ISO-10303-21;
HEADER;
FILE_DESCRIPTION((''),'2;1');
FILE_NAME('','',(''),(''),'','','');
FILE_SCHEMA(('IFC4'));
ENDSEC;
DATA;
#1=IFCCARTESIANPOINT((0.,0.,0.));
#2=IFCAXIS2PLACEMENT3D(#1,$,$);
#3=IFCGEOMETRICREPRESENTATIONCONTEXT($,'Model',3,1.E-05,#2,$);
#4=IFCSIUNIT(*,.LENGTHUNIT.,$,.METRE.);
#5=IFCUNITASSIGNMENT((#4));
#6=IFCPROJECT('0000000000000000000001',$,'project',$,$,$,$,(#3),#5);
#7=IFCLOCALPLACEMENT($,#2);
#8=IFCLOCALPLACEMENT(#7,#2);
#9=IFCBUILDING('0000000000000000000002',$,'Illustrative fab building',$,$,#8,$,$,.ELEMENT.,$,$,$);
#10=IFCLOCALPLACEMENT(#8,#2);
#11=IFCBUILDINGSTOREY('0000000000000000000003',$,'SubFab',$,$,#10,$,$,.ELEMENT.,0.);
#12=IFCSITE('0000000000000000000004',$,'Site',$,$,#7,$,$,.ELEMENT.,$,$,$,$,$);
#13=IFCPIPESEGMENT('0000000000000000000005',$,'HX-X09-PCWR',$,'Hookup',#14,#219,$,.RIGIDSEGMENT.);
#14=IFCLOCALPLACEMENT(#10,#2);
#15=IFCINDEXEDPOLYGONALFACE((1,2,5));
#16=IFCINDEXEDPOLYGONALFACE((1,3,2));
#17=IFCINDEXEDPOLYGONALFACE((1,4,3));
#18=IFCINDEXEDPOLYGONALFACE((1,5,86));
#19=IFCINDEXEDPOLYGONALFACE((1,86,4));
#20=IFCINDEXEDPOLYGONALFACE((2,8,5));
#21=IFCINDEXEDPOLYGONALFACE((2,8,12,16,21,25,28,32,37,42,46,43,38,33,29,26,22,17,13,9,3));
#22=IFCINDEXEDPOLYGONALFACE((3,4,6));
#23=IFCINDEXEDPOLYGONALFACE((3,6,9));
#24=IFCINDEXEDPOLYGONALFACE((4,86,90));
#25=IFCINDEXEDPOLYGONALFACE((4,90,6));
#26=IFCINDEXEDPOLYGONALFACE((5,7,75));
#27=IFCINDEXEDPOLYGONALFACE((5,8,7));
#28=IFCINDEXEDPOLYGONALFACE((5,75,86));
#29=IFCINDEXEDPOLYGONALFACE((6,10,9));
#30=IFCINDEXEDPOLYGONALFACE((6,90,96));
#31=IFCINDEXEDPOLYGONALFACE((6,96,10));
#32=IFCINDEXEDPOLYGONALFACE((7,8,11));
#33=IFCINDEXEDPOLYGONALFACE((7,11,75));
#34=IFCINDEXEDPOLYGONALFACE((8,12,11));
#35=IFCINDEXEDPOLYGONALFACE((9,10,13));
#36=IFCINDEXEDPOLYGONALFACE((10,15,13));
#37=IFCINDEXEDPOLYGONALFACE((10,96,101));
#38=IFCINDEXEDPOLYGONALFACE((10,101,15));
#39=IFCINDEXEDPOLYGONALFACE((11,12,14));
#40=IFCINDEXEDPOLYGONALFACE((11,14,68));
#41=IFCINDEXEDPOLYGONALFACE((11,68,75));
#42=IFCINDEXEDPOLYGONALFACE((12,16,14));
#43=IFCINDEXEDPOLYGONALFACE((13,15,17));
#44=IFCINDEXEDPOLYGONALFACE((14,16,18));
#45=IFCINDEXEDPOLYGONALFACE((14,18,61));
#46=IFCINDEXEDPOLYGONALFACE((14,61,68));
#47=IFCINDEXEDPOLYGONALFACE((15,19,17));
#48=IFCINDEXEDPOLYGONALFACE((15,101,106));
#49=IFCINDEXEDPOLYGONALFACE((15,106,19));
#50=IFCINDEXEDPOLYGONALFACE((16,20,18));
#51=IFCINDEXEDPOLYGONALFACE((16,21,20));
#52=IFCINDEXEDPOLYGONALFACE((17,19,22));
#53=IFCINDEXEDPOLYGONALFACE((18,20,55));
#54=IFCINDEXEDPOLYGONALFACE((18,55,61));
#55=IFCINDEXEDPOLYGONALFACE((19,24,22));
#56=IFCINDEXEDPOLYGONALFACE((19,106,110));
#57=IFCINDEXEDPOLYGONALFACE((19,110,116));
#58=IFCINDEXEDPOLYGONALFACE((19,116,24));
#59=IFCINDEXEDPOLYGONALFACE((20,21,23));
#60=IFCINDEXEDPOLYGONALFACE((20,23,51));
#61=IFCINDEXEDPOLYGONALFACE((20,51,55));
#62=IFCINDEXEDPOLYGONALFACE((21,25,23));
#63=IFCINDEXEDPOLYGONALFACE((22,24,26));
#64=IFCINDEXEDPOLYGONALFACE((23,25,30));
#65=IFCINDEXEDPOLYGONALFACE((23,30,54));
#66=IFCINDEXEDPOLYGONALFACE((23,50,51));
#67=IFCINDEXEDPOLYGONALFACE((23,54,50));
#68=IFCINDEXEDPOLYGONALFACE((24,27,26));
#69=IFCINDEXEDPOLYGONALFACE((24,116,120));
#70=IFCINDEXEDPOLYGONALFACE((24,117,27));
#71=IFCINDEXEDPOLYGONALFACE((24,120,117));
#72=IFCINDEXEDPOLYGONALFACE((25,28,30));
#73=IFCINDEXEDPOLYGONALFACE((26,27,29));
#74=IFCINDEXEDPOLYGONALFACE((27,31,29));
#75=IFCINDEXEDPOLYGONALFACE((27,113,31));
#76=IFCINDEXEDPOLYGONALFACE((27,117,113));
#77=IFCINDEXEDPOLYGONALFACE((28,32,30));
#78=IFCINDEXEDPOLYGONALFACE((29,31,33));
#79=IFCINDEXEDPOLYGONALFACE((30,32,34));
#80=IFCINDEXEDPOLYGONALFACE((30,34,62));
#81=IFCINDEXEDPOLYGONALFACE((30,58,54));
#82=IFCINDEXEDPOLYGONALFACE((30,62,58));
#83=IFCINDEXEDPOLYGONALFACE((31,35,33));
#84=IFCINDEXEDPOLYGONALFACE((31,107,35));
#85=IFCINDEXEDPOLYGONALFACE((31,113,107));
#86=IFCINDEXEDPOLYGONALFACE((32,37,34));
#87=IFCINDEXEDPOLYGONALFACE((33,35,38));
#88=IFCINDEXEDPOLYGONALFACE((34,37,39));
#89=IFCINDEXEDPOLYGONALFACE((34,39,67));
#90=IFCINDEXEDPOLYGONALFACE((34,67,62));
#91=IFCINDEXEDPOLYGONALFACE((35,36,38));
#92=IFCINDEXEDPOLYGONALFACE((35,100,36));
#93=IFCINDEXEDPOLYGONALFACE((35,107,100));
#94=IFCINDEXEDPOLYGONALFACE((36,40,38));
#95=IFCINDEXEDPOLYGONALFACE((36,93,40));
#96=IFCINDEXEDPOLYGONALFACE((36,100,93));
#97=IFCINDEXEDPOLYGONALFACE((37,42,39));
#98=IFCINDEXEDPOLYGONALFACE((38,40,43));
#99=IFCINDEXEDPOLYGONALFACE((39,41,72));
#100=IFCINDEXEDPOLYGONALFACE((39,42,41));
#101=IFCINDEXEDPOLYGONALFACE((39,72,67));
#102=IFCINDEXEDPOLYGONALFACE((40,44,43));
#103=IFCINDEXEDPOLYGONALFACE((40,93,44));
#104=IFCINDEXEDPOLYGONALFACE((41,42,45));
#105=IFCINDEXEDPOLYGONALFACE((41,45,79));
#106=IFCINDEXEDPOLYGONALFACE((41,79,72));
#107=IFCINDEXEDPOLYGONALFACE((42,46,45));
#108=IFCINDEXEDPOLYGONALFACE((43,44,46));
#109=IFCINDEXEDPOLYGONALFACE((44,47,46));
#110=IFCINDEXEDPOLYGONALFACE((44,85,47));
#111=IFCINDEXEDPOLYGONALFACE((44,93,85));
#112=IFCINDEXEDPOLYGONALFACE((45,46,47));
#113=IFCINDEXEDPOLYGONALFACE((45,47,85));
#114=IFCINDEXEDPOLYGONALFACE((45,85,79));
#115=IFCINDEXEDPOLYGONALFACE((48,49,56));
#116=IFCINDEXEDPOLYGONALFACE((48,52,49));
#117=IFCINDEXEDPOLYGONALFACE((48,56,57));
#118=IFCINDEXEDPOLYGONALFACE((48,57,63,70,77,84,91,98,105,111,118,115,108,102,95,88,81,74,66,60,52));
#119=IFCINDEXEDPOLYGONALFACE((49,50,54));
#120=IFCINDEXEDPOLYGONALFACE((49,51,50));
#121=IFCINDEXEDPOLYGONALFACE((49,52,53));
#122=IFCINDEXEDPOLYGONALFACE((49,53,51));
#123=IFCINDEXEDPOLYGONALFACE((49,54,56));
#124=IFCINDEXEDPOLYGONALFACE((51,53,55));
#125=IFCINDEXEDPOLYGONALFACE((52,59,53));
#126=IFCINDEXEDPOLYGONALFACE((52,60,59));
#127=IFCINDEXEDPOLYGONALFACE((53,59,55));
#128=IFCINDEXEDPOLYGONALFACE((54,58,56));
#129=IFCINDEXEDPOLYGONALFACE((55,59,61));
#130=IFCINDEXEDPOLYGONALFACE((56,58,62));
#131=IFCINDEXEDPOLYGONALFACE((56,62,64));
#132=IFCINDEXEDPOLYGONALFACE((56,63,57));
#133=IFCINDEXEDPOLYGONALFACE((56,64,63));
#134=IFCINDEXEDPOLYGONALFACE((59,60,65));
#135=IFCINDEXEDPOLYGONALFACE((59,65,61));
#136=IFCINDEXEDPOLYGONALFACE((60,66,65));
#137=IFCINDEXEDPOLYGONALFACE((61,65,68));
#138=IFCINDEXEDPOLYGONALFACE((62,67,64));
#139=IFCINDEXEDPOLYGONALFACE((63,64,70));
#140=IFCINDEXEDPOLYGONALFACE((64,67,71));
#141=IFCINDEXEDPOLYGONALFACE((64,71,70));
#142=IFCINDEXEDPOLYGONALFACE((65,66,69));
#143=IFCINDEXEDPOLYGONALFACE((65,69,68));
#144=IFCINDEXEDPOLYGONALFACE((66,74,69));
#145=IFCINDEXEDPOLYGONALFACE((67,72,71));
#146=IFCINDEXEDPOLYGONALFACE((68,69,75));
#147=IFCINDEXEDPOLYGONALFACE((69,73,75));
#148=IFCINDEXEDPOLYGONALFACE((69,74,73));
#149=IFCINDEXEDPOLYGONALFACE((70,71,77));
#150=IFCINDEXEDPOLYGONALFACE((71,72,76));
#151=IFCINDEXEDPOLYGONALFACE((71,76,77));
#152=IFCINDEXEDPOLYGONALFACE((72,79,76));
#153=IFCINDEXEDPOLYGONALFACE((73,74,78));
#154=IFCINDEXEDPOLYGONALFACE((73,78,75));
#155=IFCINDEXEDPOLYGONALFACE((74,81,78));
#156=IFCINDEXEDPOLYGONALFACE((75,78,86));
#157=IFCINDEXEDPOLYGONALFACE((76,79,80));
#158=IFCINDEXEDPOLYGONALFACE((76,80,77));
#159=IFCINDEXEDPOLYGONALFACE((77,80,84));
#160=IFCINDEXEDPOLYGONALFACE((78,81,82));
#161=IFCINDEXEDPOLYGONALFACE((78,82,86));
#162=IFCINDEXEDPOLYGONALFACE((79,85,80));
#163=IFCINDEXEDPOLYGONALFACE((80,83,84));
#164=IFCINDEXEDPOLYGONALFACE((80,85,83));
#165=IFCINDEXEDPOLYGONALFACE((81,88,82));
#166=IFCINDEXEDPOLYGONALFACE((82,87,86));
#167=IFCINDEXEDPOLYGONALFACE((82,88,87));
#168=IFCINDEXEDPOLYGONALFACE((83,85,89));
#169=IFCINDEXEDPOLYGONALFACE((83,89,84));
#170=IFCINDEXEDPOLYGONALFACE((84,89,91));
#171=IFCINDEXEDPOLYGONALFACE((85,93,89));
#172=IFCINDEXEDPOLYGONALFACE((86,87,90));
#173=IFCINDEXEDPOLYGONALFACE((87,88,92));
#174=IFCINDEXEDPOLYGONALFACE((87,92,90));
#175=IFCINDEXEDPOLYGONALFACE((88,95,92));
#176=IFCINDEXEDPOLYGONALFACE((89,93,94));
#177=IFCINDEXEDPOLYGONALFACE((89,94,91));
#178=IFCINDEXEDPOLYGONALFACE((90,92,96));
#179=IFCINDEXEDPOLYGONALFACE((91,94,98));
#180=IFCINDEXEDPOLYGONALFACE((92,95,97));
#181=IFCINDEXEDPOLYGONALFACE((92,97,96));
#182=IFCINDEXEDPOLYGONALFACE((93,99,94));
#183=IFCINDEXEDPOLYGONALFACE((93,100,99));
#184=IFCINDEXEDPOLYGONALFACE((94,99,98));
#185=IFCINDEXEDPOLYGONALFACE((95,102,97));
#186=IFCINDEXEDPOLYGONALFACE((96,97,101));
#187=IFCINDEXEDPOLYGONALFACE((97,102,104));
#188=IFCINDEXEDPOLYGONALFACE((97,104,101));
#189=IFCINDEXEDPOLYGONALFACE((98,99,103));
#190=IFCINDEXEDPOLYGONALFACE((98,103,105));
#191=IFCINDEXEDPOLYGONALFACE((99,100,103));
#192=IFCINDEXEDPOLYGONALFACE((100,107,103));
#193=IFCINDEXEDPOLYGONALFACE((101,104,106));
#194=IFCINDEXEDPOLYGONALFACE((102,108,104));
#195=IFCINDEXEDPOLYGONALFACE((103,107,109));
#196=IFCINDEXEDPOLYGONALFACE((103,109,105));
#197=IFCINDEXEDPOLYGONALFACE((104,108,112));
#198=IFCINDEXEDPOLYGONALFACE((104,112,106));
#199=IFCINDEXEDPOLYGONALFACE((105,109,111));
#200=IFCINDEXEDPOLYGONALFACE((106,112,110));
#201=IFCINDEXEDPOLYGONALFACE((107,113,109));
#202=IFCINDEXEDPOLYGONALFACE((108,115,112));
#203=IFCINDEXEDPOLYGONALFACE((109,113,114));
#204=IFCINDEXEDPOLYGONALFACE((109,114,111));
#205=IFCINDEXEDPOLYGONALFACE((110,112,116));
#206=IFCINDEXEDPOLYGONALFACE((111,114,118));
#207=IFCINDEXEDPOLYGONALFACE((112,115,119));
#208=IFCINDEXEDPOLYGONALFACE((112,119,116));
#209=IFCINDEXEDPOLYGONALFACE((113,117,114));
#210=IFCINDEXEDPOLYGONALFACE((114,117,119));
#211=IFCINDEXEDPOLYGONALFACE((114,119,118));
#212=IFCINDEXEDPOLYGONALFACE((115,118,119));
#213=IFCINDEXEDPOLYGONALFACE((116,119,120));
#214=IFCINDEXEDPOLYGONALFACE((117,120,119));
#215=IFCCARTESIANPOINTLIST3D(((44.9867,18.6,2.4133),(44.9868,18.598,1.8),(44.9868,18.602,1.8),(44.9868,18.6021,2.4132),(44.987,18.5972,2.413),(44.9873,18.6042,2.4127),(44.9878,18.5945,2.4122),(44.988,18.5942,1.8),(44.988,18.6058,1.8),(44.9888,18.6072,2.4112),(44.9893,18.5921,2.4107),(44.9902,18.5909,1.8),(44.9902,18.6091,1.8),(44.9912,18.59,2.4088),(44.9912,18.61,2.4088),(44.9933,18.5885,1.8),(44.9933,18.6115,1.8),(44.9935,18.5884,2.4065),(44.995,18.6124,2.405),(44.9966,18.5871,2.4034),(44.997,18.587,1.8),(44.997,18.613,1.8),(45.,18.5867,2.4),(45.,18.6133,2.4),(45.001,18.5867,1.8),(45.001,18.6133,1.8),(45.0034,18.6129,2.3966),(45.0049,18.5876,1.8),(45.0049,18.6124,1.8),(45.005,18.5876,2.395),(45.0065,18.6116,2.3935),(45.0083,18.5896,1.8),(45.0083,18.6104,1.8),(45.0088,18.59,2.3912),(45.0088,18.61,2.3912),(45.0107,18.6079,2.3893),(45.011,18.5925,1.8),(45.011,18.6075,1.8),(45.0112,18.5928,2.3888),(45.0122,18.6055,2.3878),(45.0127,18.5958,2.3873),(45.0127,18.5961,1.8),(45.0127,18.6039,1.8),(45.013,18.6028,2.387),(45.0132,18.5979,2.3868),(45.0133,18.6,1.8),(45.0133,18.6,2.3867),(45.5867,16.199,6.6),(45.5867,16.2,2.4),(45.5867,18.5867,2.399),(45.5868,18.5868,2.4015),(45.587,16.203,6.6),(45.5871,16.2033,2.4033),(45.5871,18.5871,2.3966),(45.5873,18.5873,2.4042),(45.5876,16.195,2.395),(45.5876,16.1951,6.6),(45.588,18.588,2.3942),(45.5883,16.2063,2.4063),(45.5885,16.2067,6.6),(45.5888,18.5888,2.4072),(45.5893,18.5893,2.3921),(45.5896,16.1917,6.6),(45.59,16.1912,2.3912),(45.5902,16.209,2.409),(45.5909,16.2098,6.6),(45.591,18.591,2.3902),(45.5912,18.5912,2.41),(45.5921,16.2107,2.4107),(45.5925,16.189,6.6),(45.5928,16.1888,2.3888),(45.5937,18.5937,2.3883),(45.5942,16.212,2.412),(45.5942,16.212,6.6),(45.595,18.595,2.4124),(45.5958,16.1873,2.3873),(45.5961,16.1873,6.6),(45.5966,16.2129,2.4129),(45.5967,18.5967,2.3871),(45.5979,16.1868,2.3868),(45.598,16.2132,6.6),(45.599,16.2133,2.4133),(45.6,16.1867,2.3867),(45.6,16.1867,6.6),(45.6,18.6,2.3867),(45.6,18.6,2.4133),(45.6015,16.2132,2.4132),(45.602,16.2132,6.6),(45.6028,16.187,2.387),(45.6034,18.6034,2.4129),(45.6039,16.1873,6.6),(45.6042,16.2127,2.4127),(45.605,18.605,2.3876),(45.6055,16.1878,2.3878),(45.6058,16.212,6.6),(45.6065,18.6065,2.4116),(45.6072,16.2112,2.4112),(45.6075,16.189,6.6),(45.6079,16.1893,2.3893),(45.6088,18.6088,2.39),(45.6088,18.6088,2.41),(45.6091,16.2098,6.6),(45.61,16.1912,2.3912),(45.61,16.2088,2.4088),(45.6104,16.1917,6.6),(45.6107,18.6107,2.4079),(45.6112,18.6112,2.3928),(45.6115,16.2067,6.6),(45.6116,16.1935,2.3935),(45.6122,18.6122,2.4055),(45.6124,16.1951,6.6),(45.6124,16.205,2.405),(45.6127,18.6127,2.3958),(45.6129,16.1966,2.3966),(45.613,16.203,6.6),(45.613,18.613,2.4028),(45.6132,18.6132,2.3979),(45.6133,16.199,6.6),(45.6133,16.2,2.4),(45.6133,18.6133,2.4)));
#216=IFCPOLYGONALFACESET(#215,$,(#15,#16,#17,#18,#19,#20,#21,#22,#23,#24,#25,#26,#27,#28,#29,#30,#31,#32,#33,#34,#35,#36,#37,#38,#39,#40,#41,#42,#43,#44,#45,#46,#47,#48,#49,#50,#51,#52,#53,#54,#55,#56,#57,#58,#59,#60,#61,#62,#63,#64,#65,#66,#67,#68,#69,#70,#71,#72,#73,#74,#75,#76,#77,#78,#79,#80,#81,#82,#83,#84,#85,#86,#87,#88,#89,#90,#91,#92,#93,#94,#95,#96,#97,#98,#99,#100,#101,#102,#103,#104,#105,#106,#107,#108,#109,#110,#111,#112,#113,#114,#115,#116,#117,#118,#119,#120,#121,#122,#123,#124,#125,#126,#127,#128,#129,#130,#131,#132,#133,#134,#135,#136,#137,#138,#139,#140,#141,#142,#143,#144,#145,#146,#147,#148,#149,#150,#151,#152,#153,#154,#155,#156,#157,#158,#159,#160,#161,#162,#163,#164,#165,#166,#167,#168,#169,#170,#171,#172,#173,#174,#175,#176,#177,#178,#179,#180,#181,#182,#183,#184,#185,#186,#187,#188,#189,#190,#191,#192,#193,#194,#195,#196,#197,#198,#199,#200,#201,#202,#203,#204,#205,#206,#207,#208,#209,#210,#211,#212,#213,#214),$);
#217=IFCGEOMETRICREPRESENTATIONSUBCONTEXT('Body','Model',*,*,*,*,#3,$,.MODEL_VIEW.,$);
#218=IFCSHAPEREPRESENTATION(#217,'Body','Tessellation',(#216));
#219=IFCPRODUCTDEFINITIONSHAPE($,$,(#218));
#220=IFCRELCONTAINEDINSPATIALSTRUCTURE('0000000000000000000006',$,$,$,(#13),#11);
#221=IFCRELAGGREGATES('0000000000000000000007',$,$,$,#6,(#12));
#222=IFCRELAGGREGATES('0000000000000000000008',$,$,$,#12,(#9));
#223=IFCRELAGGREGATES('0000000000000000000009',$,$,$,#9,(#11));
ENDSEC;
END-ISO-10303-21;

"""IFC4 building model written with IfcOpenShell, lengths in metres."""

from ifc_helpers import new_model, entity, si_unit, origin, place, context, subcontext, project, spatial, element, save


model = new_model("IFC4")

# Units and contexts
model_context = context("Model", 3, precision=1e-05, world=origin())
body_context = subcontext(model_context, "Body", "Model", "MODEL_VIEW")
ifc_project = project(units=[si_unit("LENGTHUNIT", "METRE")], contexts=[model_context])

# Site, building, storey
site_placement = place(None, origin())
site = spatial("IfcSite", under=ifc_project, at=site_placement, Name="Site", CompositionType="ELEMENT")
building_placement = place(site_placement, origin())
building = spatial("IfcBuilding", under=site, at=building_placement, Name="Illustrative fab building", CompositionType="ELEMENT")
storey_placement = place(building_placement, origin())
storey = spatial("IfcBuildingStorey", under=building, at=storey_placement, Name="SubFab", CompositionType="ELEMENT", Elevation=0.0)

# Pipe segment
pipe_segment_1_placement = place(storey_placement, origin())
element("IfcPipeSegment", 1, at=pipe_segment_1_placement, inside=storey, Name="HX-X09-PCWR", ObjectType="Hookup", PredefinedType="RIGIDSEGMENT", context=body_context, shape_type="AdvancedSweptSolid", body=[
    entity("IfcSweptDiskSolid", entity("IfcPolyline", [entity("IfcCartesianPoint", [45.0, 18.6, 1.8]), entity("IfcCartesianPoint", [45.0, 18.6, 2.4]), entity("IfcCartesianPoint", [45.6, 18.6, 2.4]), entity("IfcCartesianPoint", [45.6, 16.2, 2.4]), entity("IfcCartesianPoint", [45.6, 16.2, 6.6])]), 0.0133),
])

save(model, "model.ifc")
